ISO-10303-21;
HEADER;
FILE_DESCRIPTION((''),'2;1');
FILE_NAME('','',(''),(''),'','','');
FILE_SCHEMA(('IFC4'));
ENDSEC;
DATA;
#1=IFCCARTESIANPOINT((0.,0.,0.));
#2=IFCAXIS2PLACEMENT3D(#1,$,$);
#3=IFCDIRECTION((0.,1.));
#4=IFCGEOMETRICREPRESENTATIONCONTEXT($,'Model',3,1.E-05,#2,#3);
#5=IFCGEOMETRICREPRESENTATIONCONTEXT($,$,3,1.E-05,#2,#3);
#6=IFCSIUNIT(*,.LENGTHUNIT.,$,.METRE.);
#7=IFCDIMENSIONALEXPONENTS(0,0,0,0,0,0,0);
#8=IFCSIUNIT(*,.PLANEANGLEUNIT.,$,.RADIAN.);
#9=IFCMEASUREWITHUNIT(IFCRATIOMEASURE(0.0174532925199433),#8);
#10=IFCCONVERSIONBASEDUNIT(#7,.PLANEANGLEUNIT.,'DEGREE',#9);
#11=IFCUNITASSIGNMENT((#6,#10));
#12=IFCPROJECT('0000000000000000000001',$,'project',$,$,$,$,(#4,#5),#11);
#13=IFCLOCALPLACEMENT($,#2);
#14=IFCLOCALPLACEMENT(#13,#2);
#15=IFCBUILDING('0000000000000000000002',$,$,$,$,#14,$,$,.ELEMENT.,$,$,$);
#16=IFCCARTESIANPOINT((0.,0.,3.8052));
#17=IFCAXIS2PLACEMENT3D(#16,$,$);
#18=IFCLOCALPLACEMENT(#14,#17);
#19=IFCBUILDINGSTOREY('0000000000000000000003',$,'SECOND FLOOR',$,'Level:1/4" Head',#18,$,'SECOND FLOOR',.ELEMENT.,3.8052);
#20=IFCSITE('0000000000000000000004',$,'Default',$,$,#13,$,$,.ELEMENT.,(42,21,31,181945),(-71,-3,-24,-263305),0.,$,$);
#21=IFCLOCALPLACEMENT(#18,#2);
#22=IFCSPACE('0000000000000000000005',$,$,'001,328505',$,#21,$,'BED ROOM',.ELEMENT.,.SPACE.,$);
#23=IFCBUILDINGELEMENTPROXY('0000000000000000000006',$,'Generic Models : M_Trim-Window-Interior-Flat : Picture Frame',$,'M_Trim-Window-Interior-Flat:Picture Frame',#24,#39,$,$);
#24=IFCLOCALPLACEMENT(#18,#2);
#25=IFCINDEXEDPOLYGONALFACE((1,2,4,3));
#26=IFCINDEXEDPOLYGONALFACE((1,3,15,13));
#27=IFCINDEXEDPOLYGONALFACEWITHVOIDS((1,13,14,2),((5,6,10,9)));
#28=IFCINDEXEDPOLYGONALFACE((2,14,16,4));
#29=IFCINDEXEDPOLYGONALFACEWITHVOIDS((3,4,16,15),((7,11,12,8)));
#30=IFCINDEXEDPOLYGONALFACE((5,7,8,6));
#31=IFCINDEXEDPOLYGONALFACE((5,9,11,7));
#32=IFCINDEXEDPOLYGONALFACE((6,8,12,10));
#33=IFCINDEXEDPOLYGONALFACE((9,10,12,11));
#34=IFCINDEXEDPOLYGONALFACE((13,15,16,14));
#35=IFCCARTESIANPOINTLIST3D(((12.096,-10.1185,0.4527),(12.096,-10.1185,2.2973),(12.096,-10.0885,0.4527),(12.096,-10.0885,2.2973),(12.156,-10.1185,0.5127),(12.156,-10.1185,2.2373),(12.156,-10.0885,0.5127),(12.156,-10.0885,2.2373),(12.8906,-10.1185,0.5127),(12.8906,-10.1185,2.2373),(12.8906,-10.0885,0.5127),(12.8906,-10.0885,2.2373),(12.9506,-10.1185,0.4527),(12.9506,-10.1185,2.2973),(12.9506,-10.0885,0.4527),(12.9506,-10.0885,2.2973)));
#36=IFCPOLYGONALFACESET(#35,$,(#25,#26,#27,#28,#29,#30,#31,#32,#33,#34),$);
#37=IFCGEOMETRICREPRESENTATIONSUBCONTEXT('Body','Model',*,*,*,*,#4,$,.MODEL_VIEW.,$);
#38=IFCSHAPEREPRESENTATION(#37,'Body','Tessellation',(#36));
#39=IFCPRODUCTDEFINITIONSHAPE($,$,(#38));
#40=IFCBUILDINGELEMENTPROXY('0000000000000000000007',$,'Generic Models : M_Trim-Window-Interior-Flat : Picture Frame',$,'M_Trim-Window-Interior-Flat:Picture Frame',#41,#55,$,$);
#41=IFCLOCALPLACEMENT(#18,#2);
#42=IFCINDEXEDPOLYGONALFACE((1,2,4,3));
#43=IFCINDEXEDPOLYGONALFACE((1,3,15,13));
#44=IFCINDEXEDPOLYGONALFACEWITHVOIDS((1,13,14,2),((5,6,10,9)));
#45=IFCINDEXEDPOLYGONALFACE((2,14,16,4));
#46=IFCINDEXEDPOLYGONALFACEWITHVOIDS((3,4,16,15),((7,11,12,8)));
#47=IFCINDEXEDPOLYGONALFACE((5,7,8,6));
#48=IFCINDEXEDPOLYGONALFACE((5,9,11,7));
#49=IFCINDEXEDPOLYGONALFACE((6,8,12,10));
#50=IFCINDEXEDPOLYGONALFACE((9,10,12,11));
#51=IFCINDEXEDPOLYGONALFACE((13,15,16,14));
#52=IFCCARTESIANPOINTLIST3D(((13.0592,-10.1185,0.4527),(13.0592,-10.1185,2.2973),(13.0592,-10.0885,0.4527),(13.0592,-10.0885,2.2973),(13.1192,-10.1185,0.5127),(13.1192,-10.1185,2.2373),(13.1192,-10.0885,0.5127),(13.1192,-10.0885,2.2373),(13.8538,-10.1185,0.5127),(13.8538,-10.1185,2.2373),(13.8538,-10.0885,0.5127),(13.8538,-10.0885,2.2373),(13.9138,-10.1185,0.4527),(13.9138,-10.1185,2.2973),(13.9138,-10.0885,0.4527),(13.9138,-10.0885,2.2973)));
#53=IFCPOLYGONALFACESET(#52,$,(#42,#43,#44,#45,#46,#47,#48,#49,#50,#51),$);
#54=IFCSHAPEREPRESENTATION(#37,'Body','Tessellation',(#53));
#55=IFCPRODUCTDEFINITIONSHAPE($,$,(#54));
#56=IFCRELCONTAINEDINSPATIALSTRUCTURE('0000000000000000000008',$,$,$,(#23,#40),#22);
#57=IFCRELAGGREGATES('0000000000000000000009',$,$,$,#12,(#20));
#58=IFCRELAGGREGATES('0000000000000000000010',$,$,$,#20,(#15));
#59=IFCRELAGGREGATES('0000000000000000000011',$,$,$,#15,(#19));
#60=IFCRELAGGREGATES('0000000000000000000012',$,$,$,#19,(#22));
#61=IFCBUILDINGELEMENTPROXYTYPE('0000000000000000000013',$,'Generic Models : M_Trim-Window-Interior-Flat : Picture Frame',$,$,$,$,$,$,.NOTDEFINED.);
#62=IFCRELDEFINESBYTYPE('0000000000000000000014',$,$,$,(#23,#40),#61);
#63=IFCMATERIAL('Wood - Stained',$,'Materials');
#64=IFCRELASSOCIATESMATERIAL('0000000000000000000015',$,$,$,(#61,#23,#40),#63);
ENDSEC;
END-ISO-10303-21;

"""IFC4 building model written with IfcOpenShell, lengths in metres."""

from ifc_helpers import new_model, entity, si_unit, converted_unit, direction, frame, origin, place, context, subcontext, project, spatial, polyline, outline, extrude, source, transform, mapped, material, type_object, type_shapes, element, save


model = new_model("IFC4")

# Units and contexts
model_context = context("Model", 3, precision=1e-05, world=origin(), true_north=direction((0.0, 1.0)))
context_of_model = context(None, 3, precision=1e-05, world=origin(), true_north=direction((0.0, 1.0)))
body_context = subcontext(model_context, "Body", "Model", "MODEL_VIEW")
ifc_project = project(units=[si_unit("LENGTHUNIT", "METRE"), converted_unit("PLANEANGLEUNIT", "DEGREE", entity("IfcRatioMeasure", 0.0174532925199433), si_unit("PLANEANGLEUNIT", "RADIAN"), dimensions=[0, 0, 0, 0, 0, 0, 0])], contexts=[model_context, context_of_model])

# Site, building, storey
site_placement = place(None, origin())
site = spatial("IfcSite", under=ifc_project, at=site_placement, Name="Default", CompositionType="ELEMENT", RefLatitude=(42, 21, 31, 181945), RefLongitude=(-71, -3, -24, -263305), RefElevation=0.0)
building_placement = place(site_placement, origin())
building = spatial("IfcBuilding", under=site, at=building_placement, CompositionType="ELEMENT")
storey_placement = place(building_placement, frame((0.0, 0.0, 3.8052)))
storey = spatial("IfcBuildingStorey", under=building, at=storey_placement, Name="SECOND FLOOR", ObjectType="Level:1/4\" Head", LongName="SECOND FLOOR", CompositionType="ELEMENT", Elevation=3.8052)

# Shared definitions
ifc_material_1 = material(Name="Wood - Stained", Category="Materials")

# Shared definitions
space_placement = place(storey_placement, origin())
space = spatial("IfcSpace", under=storey, at=space_placement, Description="001,328505", LongName="BED ROOM", CompositionType="ELEMENT", PredefinedType="SPACE")

# Building element proxies
building_element_proxy_type_1 = type_object("IfcBuildingElementProxyType", Name="Generic Models : M_Trim-Window-Interior-Flat : Picture Frame", PredefinedType="NOTDEFINED", material=ifc_material_1)
shared_shape_1 = source(origin(), body_context, "Body", "SweptSolid", [
    extrude(outline(polyline([(-0.4273, -0.9223), (0.4273, -0.9223), (0.4273, 0.9223), (-0.4273, 0.9223), (-0.4273, -0.9223)]), holes=[polyline([(-0.3673, -0.8623), (-0.3673, 0.8623), (0.3673, 0.8623), (0.3673, -0.8623), (-0.3673, -0.8623)])]), frame((0.0, -0.875, 0.0), z_axis=(0.0, 0.0, 1.0), x_axis=(-1.0, 0.0, 0.0)), (0.0, 0.0, 1.0), 0.03),
])
type_shapes(building_element_proxy_type_1, [shared_shape_1])
for number, where, z_axis, x_axis, name in (
    (1, (12.5233, -10.1185, 2.25), (0.0, 1.0, 0.0), (-1.0, 0.0, 0.0), "Generic Models : M_Trim-Window-Interior-Flat : Picture Frame"),
    (2, (13.4865, -10.1185, 2.25), (0.0, 1.0, 0.0), (-1.0, 0.0, 0.0), "Generic Models : M_Trim-Window-Interior-Flat : Picture Frame"),
):
    element("IfcBuildingElementProxy", number, at=place(space_placement, frame(where, z_axis=z_axis, x_axis=x_axis)), inside=space, type_object=building_element_proxy_type_1, material=ifc_material_1, Name=name, ObjectType="M_Trim-Window-Interior-Flat:Picture Frame", context=body_context, shape_type="MappedRepresentation", body=[
        mapped(shared_shape_1, transform((0.0, 0.0, 0.0), scale=1.0)),
    ])

save(model, "model.ifc")
